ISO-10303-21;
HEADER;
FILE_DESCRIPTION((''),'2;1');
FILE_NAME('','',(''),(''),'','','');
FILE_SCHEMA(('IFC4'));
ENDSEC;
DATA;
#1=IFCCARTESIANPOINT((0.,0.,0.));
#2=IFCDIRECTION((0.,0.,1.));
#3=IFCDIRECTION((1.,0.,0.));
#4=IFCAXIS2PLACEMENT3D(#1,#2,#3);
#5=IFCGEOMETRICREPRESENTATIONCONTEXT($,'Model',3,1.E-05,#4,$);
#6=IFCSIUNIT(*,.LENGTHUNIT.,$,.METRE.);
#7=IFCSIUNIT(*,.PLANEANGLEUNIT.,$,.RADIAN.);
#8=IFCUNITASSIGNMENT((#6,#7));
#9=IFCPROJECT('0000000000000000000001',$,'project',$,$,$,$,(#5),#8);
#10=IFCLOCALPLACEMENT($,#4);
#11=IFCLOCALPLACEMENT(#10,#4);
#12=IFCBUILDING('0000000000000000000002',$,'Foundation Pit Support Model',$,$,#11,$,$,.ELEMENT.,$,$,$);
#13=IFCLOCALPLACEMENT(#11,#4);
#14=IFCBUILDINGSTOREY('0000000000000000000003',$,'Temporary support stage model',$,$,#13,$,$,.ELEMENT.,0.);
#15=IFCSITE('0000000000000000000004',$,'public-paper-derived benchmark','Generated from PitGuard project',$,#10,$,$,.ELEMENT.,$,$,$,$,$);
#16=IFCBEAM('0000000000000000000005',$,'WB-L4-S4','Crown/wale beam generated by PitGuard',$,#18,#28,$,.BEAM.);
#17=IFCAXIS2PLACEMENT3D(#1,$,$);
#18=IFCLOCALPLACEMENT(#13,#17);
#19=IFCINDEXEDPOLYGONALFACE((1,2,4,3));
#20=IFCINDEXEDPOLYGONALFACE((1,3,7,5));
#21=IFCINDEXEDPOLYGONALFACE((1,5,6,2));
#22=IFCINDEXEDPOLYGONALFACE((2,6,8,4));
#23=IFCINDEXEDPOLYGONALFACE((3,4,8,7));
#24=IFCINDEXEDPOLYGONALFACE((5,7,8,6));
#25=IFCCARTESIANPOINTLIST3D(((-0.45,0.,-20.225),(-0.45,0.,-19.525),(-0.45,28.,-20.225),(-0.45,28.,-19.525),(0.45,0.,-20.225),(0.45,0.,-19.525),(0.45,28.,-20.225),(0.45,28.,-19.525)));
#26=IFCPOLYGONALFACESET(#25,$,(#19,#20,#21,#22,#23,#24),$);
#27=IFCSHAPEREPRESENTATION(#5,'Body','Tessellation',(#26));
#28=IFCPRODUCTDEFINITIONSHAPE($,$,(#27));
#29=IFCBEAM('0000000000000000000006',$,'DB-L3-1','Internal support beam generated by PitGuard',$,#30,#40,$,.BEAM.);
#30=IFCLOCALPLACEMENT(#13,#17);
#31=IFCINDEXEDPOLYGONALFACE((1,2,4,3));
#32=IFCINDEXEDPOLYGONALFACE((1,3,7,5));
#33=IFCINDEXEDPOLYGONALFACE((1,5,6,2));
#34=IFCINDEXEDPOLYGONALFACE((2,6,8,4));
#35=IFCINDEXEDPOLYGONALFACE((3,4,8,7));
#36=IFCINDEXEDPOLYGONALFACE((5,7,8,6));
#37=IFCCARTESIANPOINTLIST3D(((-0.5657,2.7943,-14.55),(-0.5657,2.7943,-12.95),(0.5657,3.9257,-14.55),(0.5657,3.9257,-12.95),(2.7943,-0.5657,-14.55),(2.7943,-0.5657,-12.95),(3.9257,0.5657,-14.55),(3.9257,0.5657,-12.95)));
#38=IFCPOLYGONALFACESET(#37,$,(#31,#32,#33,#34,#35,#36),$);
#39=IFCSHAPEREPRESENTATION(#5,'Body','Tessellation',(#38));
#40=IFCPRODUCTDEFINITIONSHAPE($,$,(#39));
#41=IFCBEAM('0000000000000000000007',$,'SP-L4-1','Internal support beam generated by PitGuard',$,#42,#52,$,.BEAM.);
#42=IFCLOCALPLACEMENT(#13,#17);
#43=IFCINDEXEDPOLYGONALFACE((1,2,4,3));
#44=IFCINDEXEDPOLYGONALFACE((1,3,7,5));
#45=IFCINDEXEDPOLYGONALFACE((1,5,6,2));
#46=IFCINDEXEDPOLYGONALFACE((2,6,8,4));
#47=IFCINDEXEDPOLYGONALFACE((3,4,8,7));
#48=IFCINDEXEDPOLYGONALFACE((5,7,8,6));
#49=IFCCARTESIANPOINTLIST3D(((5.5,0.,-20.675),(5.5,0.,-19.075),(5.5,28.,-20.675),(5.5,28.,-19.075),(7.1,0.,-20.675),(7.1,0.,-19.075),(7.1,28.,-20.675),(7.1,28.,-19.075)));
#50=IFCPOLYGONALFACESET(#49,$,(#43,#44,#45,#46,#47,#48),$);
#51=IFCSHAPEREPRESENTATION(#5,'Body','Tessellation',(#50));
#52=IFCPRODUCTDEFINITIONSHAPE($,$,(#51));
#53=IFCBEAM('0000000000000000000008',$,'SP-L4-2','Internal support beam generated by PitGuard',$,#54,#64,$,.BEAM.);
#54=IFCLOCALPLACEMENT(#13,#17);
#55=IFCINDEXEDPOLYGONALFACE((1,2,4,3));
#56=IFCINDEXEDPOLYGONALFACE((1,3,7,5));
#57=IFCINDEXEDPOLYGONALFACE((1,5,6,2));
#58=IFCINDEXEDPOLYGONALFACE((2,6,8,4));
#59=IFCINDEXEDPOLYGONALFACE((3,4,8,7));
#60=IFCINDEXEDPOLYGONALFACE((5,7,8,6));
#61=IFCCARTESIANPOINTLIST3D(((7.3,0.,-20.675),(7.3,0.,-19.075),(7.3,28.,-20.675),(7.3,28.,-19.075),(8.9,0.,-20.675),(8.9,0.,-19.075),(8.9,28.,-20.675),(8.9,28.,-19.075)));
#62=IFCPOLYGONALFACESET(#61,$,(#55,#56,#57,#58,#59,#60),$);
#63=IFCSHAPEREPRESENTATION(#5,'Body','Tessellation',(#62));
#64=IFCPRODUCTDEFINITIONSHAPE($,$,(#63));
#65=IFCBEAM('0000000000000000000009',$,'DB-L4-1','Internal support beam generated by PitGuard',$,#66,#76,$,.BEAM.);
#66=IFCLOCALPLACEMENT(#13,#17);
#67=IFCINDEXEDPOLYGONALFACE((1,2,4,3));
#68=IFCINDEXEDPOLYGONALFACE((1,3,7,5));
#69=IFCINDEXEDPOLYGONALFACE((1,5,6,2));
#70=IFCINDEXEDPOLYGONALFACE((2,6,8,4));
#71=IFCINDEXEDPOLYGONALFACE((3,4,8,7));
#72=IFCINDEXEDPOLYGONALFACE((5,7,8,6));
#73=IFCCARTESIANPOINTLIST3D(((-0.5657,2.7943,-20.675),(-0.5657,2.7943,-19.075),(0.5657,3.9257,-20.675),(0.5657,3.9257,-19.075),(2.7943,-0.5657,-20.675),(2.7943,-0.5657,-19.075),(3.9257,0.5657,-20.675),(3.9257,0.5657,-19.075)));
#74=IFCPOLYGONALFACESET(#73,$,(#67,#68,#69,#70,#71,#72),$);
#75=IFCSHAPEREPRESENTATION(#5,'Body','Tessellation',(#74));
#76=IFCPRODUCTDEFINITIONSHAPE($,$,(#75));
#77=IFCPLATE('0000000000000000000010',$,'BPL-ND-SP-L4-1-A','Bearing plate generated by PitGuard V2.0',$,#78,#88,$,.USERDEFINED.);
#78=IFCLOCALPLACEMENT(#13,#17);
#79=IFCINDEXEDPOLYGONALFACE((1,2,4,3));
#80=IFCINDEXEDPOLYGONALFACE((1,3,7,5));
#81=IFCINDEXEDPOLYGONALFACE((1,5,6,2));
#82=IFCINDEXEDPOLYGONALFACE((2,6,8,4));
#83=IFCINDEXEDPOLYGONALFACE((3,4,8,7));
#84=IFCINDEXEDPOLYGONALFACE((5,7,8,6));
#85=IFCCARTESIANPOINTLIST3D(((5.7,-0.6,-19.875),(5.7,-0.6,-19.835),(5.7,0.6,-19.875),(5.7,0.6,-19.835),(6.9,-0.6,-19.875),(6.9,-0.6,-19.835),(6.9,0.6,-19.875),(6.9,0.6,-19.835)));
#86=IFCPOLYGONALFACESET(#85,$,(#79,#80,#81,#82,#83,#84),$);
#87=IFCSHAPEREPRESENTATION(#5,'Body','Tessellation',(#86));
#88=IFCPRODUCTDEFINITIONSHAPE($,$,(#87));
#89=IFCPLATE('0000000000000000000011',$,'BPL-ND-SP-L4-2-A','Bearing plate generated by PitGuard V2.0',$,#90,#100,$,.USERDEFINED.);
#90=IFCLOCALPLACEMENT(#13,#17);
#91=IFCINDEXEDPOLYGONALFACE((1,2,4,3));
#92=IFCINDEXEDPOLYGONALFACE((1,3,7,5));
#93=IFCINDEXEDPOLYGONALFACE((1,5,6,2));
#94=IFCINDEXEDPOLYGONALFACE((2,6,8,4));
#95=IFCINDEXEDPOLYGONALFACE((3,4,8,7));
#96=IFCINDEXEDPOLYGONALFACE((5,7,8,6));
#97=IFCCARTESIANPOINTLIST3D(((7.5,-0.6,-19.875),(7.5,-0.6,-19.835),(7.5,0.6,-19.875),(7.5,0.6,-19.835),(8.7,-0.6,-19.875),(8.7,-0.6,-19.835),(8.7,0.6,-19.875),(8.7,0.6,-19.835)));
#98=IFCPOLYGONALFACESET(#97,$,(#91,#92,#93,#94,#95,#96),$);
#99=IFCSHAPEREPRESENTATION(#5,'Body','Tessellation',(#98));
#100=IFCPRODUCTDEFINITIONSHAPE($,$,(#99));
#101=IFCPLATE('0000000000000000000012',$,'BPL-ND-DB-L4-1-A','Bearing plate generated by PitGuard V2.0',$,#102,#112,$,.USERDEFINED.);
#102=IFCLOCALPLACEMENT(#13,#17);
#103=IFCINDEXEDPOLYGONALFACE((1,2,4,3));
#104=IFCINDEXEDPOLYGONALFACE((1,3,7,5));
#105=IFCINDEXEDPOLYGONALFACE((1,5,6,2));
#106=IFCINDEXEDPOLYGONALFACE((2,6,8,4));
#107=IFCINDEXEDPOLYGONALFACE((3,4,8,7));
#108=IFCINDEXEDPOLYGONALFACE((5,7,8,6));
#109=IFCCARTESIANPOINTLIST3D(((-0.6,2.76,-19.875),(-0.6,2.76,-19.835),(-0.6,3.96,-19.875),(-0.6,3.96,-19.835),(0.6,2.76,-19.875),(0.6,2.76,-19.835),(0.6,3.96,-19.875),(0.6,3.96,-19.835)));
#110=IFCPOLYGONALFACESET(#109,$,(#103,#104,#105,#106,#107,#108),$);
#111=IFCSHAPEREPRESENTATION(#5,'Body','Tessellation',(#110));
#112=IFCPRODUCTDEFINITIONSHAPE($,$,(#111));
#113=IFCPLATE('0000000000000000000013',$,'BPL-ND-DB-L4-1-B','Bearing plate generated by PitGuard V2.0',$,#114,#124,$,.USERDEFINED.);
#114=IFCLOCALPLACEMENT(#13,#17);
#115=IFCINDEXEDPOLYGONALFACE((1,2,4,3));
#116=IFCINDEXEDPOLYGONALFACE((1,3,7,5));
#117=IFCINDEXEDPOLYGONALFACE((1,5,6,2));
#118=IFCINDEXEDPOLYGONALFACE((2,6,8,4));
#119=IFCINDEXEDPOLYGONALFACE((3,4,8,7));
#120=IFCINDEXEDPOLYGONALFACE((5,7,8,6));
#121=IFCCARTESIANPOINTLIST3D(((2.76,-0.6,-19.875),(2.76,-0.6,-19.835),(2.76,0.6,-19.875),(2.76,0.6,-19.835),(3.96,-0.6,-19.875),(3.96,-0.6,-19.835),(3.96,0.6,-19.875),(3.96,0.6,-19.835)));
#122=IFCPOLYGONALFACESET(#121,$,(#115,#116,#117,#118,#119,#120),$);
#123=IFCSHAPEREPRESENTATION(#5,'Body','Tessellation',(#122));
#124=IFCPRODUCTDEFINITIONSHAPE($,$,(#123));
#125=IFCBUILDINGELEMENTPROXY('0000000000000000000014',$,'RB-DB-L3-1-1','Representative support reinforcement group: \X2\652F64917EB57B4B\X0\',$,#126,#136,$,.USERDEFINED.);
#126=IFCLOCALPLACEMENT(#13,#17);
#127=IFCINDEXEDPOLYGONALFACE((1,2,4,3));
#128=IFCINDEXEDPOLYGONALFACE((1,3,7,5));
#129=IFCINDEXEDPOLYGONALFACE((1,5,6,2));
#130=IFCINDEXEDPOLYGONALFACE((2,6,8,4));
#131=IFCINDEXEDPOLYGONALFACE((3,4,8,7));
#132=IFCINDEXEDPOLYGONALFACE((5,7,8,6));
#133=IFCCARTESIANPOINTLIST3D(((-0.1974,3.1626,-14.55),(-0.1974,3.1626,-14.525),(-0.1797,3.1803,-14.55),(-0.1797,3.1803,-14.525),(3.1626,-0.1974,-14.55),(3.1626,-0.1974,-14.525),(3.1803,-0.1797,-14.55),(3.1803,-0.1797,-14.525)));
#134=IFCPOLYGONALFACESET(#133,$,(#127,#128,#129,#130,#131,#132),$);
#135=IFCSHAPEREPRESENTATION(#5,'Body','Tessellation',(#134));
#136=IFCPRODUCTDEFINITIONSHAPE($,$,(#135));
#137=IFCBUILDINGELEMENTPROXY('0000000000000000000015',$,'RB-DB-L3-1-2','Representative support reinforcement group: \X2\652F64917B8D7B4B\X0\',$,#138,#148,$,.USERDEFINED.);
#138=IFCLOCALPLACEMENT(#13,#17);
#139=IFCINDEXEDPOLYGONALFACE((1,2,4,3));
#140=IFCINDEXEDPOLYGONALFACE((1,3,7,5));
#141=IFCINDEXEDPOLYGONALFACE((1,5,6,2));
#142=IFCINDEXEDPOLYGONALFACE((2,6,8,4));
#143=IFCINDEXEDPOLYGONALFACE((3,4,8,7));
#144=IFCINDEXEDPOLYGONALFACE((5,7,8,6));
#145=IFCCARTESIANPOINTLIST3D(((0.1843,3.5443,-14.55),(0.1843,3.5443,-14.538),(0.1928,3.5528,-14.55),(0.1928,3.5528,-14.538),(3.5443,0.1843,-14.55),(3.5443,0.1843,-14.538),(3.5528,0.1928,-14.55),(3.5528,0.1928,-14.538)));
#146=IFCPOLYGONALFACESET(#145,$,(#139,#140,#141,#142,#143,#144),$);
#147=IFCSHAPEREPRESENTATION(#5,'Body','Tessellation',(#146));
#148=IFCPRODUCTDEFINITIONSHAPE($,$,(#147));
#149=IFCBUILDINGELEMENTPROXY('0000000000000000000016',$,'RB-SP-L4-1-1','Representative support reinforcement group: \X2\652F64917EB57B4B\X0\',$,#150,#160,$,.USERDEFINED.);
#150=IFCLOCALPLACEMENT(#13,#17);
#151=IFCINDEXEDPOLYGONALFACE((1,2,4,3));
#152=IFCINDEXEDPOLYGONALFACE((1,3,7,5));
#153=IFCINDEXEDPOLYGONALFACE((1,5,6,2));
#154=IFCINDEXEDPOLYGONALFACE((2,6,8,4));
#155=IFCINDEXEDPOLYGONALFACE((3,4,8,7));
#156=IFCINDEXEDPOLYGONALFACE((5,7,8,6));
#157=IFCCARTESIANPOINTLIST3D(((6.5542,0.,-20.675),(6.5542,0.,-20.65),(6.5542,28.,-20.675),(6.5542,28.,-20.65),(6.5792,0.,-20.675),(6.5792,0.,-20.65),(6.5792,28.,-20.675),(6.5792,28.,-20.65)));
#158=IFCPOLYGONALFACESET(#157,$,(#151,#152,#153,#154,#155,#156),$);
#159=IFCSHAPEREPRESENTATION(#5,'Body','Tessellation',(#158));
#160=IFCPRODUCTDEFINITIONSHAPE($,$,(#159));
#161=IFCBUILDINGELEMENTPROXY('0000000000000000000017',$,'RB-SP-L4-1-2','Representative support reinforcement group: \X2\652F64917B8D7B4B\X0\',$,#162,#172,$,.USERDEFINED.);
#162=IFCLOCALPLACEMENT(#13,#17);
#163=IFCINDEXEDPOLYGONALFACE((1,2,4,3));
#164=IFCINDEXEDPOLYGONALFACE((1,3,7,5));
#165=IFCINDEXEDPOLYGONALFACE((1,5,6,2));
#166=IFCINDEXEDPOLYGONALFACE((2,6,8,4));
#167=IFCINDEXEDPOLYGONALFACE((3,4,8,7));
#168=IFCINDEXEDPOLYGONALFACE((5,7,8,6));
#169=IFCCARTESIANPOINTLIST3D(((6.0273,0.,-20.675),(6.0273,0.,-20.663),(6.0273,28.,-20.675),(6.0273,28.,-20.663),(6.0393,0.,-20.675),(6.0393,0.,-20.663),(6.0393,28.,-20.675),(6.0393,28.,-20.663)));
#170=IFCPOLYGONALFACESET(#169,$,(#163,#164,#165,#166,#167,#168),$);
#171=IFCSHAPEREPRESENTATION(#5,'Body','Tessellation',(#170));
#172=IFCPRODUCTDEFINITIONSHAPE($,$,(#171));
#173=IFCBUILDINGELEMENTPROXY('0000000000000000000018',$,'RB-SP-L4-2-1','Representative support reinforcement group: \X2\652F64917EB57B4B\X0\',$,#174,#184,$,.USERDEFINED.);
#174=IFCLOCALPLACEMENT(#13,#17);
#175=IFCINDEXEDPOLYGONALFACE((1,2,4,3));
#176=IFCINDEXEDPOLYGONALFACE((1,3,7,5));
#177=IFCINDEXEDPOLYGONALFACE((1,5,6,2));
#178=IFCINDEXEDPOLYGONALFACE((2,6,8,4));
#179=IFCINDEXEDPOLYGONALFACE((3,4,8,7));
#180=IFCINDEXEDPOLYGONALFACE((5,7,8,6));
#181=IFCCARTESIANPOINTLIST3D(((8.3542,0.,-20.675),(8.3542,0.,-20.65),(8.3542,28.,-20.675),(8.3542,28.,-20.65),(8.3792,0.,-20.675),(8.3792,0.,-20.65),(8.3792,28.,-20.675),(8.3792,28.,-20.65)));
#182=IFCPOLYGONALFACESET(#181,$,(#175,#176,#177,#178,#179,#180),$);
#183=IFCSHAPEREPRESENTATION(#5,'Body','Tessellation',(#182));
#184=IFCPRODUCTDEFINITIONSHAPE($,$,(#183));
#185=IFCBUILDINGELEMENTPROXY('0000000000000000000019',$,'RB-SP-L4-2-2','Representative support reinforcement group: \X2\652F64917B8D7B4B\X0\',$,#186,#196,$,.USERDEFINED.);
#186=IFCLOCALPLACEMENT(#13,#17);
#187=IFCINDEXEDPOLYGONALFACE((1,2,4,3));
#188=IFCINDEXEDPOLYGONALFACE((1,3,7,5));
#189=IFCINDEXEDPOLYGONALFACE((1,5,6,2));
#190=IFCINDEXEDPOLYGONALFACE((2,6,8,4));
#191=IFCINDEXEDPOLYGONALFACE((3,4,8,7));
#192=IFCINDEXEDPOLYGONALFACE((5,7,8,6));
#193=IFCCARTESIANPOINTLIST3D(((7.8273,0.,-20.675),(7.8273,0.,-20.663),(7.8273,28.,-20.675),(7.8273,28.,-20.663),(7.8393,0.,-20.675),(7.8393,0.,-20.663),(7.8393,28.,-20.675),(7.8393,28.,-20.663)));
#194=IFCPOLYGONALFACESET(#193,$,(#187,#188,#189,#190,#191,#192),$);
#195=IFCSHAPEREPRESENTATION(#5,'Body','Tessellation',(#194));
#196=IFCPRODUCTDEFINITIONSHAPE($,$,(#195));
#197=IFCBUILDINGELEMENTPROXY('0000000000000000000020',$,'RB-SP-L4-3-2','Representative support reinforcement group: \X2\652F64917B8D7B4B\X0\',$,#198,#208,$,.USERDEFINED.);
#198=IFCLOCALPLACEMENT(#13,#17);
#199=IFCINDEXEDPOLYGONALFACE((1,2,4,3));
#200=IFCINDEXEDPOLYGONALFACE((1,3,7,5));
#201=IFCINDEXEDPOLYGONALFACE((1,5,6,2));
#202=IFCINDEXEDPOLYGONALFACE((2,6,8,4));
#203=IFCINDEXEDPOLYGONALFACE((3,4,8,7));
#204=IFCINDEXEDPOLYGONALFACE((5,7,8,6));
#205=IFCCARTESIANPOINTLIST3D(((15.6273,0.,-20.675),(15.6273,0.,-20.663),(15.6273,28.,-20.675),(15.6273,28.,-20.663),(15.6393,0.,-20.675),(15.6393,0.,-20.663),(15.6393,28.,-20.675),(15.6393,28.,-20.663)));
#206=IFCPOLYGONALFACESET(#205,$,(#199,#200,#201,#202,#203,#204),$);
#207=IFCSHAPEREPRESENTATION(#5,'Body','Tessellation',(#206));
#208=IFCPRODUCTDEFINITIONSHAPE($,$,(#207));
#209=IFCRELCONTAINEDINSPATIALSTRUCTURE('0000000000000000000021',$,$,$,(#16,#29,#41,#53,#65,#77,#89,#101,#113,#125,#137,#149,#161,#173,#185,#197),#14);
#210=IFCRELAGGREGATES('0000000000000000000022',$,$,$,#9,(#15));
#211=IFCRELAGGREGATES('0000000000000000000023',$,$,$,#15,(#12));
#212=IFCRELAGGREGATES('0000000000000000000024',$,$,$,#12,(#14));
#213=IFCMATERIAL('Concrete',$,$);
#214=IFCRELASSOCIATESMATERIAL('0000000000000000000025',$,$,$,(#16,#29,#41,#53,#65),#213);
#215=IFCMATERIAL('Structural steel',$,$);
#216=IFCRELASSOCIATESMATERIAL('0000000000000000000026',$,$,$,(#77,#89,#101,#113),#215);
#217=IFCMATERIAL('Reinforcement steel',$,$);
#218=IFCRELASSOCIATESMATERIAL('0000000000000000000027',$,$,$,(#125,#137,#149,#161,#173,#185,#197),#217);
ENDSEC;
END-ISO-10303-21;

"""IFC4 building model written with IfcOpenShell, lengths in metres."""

from ifc_helpers import new_model, si_unit, frame, origin_with_axes, origin_2d, place, context, project, spatial, rectangle, extrude, material, element, save


model = new_model("IFC4")

# Units and contexts
model_context = context("Model", 3, precision=1e-05, world=origin_with_axes())
ifc_project = project(units=[si_unit("LENGTHUNIT", "METRE"), si_unit("PLANEANGLEUNIT", "RADIAN")], contexts=[model_context])

# Site, building, storey
site_placement = place(None, origin_with_axes())
site = spatial("IfcSite", under=ifc_project, at=site_placement, Name="public-paper-derived benchmark", Description="Generated from PitGuard project", CompositionType="ELEMENT")
building_placement = place(site_placement, origin_with_axes())
building = spatial("IfcBuilding", under=site, at=building_placement, Name="Foundation Pit Support Model", CompositionType="ELEMENT")
storey_placement = place(building_placement, origin_with_axes())
storey = spatial("IfcBuildingStorey", under=building, at=storey_placement, Name="Temporary support stage model", CompositionType="ELEMENT", Elevation=0.0)

# Beams
ifc_material_1 = material(Name="Concrete")
beam_1_placement = place(storey_placement, frame((0.0, 14.0, -20.225), z_axis=(0.0, 0.0, 1.0), x_axis=(0.0, -1.0, 0.0)))
element("IfcBeam", 1, at=beam_1_placement, inside=storey, material=ifc_material_1, Name="WB-L4-S4", Description="Crown/wale beam generated by PitGuard", PredefinedType="BEAM", context=model_context, shape_type="SweptSolid", body=[
    extrude(rectangle(XDim=28.0, YDim=0.9, at=origin_2d()), origin_with_axes(), (0.0, 0.0, 1.0), 0.7),
])
beam_2_placement = place(storey_placement, frame((1.68, 1.68, -14.55), z_axis=(0.0, 0.0, 1.0), x_axis=(0.707107, -0.707107, 0.0)))
element("IfcBeam", 2, at=beam_2_placement, inside=storey, material=ifc_material_1, Name="DB-L3-1", Description="Internal support beam generated by PitGuard", PredefinedType="BEAM", context=model_context, shape_type="SweptSolid", body=[
    extrude(rectangle(XDim=4.7518, YDim=1.6, at=origin_2d()), origin_with_axes(), (0.0, 0.0, 1.0), 1.6),
])
for number, where, z_axis, x_axis, name in (
    (3, (6.3, 14.0, -20.675), (0.0, 0.0, 1.0), (0.0, 1.0, 0.0), "SP-L4-1"),
    (4, (8.1, 14.0, -20.675), (0.0, 0.0, 1.0), (0.0, 1.0, 0.0), "SP-L4-2"),
):
    element("IfcBeam", number, at=place(storey_placement, frame(where, z_axis=z_axis, x_axis=x_axis)), inside=storey, material=ifc_material_1, Name=name, Description="Internal support beam generated by PitGuard", PredefinedType="BEAM", context=model_context, shape_type="SweptSolid", body=[
        extrude(rectangle(XDim=28.0, YDim=1.6, at=origin_2d()), origin_with_axes(), (0.0, 0.0, 1.0), 1.6),
    ])
beam_3_placement = place(storey_placement, frame((1.68, 1.68, -20.675), z_axis=(0.0, 0.0, 1.0), x_axis=(0.707107, -0.707107, 0.0)))
element("IfcBeam", 5, at=beam_3_placement, inside=storey, material=ifc_material_1, Name="DB-L4-1", Description="Internal support beam generated by PitGuard", PredefinedType="BEAM", context=model_context, shape_type="SweptSolid", body=[
    extrude(rectangle(XDim=4.7518, YDim=1.6, at=origin_2d()), origin_with_axes(), (0.0, 0.0, 1.0), 1.6),
])

# Plates
ifc_material_2 = material(Name="Structural steel")
for number, where, z_axis, x_axis, name in (
    (6, (6.3, 0.0, -19.875), (0.0, 0.0, 1.0), (1.0, 0.0, 0.0), "BPL-ND-SP-L4-1-A"),
    (7, (8.1, 0.0, -19.875), (0.0, 0.0, 1.0), (1.0, 0.0, 0.0), "BPL-ND-SP-L4-2-A"),
    (8, (0.0, 3.36, -19.875), (0.0, 0.0, 1.0), (1.0, 0.0, 0.0), "BPL-ND-DB-L4-1-A"),
    (9, (3.36, 0.0, -19.875), (0.0, 0.0, 1.0), (1.0, 0.0, 0.0), "BPL-ND-DB-L4-1-B"),
):
    element("IfcPlate", number, at=place(storey_placement, frame(where, z_axis=z_axis, x_axis=x_axis)), inside=storey, material=ifc_material_2, Name=name, Description="Bearing plate generated by PitGuard V2.0", PredefinedType="USERDEFINED", context=model_context, shape_type="SweptSolid", body=[
        extrude(rectangle(XDim=1.2, YDim=1.2, at=origin_2d()), origin_with_axes(), (0.0, 0.0, 1.0), 0.04),
    ])

# Building element proxies
ifc_material_3 = material(Name="Reinforcement steel")
proxy_1_placement = place(storey_placement, frame((1.4914, 1.4914, -14.55), z_axis=(0.0, 0.0, 1.0), x_axis=(0.707107, -0.707107, 0.0)))
element("IfcBuildingElementProxy", 10, at=proxy_1_placement, inside=storey, material=ifc_material_3, Name="RB-DB-L3-1-1", Description="Representative support reinforcement group: 支撑纵筋", PredefinedType="USERDEFINED", context=model_context, shape_type="SweptSolid", body=[
    extrude(rectangle(XDim=4.7518, YDim=0.025, at=origin_2d()), origin_with_axes(), (0.0, 0.0, 1.0), 0.025),
])
proxy_2_placement = place(storey_placement, frame((1.8686, 1.8686, -14.55), z_axis=(0.0, 0.0, 1.0), x_axis=(0.707107, -0.707107, 0.0)))
element("IfcBuildingElementProxy", 11, at=proxy_2_placement, inside=storey, material=ifc_material_3, Name="RB-DB-L3-1-2", Description="Representative support reinforcement group: 支撑箍筋", PredefinedType="USERDEFINED", context=model_context, shape_type="SweptSolid", body=[
    extrude(rectangle(XDim=4.7518, YDim=0.012, at=origin_2d()), origin_with_axes(), (0.0, 0.0, 1.0), 0.012),
])
proxy_3_placement = place(storey_placement, frame((6.5667, 14.0, -20.675), z_axis=(0.0, 0.0, 1.0), x_axis=(0.0, 1.0, 0.0)))
element("IfcBuildingElementProxy", 12, at=proxy_3_placement, inside=storey, material=ifc_material_3, Name="RB-SP-L4-1-1", Description="Representative support reinforcement group: 支撑纵筋", PredefinedType="USERDEFINED", context=model_context, shape_type="SweptSolid", body=[
    extrude(rectangle(XDim=28.0, YDim=0.025, at=origin_2d()), origin_with_axes(), (0.0, 0.0, 1.0), 0.025),
])
proxy_4_placement = place(storey_placement, frame((6.0333, 14.0, -20.675), z_axis=(0.0, 0.0, 1.0), x_axis=(0.0, 1.0, 0.0)))
element("IfcBuildingElementProxy", 13, at=proxy_4_placement, inside=storey, material=ifc_material_3, Name="RB-SP-L4-1-2", Description="Representative support reinforcement group: 支撑箍筋", PredefinedType="USERDEFINED", context=model_context, shape_type="SweptSolid", body=[
    extrude(rectangle(XDim=28.0, YDim=0.012, at=origin_2d()), origin_with_axes(), (0.0, 0.0, 1.0), 0.012),
])
proxy_5_placement = place(storey_placement, frame((8.3667, 14.0, -20.675), z_axis=(0.0, 0.0, 1.0), x_axis=(0.0, 1.0, 0.0)))
element("IfcBuildingElementProxy", 14, at=proxy_5_placement, inside=storey, material=ifc_material_3, Name="RB-SP-L4-2-1", Description="Representative support reinforcement group: 支撑纵筋", PredefinedType="USERDEFINED", context=model_context, shape_type="SweptSolid", body=[
    extrude(rectangle(XDim=28.0, YDim=0.025, at=origin_2d()), origin_with_axes(), (0.0, 0.0, 1.0), 0.025),
])
for number, where, z_axis, x_axis, name in (
    (15, (7.8333, 14.0, -20.675), (0.0, 0.0, 1.0), (0.0, 1.0, 0.0), "RB-SP-L4-2-2"),
    (16, (15.6333, 14.0, -20.675), (0.0, 0.0, 1.0), (0.0, 1.0, 0.0), "RB-SP-L4-3-2"),
):
    element("IfcBuildingElementProxy", number, at=place(storey_placement, frame(where, z_axis=z_axis, x_axis=x_axis)), inside=storey, material=ifc_material_3, Name=name, Description="Representative support reinforcement group: 支撑箍筋", PredefinedType="USERDEFINED", context=model_context, shape_type="SweptSolid", body=[
        extrude(rectangle(XDim=28.0, YDim=0.012, at=origin_2d()), origin_with_axes(), (0.0, 0.0, 1.0), 0.012),
    ])

save(model, "model.ifc")
